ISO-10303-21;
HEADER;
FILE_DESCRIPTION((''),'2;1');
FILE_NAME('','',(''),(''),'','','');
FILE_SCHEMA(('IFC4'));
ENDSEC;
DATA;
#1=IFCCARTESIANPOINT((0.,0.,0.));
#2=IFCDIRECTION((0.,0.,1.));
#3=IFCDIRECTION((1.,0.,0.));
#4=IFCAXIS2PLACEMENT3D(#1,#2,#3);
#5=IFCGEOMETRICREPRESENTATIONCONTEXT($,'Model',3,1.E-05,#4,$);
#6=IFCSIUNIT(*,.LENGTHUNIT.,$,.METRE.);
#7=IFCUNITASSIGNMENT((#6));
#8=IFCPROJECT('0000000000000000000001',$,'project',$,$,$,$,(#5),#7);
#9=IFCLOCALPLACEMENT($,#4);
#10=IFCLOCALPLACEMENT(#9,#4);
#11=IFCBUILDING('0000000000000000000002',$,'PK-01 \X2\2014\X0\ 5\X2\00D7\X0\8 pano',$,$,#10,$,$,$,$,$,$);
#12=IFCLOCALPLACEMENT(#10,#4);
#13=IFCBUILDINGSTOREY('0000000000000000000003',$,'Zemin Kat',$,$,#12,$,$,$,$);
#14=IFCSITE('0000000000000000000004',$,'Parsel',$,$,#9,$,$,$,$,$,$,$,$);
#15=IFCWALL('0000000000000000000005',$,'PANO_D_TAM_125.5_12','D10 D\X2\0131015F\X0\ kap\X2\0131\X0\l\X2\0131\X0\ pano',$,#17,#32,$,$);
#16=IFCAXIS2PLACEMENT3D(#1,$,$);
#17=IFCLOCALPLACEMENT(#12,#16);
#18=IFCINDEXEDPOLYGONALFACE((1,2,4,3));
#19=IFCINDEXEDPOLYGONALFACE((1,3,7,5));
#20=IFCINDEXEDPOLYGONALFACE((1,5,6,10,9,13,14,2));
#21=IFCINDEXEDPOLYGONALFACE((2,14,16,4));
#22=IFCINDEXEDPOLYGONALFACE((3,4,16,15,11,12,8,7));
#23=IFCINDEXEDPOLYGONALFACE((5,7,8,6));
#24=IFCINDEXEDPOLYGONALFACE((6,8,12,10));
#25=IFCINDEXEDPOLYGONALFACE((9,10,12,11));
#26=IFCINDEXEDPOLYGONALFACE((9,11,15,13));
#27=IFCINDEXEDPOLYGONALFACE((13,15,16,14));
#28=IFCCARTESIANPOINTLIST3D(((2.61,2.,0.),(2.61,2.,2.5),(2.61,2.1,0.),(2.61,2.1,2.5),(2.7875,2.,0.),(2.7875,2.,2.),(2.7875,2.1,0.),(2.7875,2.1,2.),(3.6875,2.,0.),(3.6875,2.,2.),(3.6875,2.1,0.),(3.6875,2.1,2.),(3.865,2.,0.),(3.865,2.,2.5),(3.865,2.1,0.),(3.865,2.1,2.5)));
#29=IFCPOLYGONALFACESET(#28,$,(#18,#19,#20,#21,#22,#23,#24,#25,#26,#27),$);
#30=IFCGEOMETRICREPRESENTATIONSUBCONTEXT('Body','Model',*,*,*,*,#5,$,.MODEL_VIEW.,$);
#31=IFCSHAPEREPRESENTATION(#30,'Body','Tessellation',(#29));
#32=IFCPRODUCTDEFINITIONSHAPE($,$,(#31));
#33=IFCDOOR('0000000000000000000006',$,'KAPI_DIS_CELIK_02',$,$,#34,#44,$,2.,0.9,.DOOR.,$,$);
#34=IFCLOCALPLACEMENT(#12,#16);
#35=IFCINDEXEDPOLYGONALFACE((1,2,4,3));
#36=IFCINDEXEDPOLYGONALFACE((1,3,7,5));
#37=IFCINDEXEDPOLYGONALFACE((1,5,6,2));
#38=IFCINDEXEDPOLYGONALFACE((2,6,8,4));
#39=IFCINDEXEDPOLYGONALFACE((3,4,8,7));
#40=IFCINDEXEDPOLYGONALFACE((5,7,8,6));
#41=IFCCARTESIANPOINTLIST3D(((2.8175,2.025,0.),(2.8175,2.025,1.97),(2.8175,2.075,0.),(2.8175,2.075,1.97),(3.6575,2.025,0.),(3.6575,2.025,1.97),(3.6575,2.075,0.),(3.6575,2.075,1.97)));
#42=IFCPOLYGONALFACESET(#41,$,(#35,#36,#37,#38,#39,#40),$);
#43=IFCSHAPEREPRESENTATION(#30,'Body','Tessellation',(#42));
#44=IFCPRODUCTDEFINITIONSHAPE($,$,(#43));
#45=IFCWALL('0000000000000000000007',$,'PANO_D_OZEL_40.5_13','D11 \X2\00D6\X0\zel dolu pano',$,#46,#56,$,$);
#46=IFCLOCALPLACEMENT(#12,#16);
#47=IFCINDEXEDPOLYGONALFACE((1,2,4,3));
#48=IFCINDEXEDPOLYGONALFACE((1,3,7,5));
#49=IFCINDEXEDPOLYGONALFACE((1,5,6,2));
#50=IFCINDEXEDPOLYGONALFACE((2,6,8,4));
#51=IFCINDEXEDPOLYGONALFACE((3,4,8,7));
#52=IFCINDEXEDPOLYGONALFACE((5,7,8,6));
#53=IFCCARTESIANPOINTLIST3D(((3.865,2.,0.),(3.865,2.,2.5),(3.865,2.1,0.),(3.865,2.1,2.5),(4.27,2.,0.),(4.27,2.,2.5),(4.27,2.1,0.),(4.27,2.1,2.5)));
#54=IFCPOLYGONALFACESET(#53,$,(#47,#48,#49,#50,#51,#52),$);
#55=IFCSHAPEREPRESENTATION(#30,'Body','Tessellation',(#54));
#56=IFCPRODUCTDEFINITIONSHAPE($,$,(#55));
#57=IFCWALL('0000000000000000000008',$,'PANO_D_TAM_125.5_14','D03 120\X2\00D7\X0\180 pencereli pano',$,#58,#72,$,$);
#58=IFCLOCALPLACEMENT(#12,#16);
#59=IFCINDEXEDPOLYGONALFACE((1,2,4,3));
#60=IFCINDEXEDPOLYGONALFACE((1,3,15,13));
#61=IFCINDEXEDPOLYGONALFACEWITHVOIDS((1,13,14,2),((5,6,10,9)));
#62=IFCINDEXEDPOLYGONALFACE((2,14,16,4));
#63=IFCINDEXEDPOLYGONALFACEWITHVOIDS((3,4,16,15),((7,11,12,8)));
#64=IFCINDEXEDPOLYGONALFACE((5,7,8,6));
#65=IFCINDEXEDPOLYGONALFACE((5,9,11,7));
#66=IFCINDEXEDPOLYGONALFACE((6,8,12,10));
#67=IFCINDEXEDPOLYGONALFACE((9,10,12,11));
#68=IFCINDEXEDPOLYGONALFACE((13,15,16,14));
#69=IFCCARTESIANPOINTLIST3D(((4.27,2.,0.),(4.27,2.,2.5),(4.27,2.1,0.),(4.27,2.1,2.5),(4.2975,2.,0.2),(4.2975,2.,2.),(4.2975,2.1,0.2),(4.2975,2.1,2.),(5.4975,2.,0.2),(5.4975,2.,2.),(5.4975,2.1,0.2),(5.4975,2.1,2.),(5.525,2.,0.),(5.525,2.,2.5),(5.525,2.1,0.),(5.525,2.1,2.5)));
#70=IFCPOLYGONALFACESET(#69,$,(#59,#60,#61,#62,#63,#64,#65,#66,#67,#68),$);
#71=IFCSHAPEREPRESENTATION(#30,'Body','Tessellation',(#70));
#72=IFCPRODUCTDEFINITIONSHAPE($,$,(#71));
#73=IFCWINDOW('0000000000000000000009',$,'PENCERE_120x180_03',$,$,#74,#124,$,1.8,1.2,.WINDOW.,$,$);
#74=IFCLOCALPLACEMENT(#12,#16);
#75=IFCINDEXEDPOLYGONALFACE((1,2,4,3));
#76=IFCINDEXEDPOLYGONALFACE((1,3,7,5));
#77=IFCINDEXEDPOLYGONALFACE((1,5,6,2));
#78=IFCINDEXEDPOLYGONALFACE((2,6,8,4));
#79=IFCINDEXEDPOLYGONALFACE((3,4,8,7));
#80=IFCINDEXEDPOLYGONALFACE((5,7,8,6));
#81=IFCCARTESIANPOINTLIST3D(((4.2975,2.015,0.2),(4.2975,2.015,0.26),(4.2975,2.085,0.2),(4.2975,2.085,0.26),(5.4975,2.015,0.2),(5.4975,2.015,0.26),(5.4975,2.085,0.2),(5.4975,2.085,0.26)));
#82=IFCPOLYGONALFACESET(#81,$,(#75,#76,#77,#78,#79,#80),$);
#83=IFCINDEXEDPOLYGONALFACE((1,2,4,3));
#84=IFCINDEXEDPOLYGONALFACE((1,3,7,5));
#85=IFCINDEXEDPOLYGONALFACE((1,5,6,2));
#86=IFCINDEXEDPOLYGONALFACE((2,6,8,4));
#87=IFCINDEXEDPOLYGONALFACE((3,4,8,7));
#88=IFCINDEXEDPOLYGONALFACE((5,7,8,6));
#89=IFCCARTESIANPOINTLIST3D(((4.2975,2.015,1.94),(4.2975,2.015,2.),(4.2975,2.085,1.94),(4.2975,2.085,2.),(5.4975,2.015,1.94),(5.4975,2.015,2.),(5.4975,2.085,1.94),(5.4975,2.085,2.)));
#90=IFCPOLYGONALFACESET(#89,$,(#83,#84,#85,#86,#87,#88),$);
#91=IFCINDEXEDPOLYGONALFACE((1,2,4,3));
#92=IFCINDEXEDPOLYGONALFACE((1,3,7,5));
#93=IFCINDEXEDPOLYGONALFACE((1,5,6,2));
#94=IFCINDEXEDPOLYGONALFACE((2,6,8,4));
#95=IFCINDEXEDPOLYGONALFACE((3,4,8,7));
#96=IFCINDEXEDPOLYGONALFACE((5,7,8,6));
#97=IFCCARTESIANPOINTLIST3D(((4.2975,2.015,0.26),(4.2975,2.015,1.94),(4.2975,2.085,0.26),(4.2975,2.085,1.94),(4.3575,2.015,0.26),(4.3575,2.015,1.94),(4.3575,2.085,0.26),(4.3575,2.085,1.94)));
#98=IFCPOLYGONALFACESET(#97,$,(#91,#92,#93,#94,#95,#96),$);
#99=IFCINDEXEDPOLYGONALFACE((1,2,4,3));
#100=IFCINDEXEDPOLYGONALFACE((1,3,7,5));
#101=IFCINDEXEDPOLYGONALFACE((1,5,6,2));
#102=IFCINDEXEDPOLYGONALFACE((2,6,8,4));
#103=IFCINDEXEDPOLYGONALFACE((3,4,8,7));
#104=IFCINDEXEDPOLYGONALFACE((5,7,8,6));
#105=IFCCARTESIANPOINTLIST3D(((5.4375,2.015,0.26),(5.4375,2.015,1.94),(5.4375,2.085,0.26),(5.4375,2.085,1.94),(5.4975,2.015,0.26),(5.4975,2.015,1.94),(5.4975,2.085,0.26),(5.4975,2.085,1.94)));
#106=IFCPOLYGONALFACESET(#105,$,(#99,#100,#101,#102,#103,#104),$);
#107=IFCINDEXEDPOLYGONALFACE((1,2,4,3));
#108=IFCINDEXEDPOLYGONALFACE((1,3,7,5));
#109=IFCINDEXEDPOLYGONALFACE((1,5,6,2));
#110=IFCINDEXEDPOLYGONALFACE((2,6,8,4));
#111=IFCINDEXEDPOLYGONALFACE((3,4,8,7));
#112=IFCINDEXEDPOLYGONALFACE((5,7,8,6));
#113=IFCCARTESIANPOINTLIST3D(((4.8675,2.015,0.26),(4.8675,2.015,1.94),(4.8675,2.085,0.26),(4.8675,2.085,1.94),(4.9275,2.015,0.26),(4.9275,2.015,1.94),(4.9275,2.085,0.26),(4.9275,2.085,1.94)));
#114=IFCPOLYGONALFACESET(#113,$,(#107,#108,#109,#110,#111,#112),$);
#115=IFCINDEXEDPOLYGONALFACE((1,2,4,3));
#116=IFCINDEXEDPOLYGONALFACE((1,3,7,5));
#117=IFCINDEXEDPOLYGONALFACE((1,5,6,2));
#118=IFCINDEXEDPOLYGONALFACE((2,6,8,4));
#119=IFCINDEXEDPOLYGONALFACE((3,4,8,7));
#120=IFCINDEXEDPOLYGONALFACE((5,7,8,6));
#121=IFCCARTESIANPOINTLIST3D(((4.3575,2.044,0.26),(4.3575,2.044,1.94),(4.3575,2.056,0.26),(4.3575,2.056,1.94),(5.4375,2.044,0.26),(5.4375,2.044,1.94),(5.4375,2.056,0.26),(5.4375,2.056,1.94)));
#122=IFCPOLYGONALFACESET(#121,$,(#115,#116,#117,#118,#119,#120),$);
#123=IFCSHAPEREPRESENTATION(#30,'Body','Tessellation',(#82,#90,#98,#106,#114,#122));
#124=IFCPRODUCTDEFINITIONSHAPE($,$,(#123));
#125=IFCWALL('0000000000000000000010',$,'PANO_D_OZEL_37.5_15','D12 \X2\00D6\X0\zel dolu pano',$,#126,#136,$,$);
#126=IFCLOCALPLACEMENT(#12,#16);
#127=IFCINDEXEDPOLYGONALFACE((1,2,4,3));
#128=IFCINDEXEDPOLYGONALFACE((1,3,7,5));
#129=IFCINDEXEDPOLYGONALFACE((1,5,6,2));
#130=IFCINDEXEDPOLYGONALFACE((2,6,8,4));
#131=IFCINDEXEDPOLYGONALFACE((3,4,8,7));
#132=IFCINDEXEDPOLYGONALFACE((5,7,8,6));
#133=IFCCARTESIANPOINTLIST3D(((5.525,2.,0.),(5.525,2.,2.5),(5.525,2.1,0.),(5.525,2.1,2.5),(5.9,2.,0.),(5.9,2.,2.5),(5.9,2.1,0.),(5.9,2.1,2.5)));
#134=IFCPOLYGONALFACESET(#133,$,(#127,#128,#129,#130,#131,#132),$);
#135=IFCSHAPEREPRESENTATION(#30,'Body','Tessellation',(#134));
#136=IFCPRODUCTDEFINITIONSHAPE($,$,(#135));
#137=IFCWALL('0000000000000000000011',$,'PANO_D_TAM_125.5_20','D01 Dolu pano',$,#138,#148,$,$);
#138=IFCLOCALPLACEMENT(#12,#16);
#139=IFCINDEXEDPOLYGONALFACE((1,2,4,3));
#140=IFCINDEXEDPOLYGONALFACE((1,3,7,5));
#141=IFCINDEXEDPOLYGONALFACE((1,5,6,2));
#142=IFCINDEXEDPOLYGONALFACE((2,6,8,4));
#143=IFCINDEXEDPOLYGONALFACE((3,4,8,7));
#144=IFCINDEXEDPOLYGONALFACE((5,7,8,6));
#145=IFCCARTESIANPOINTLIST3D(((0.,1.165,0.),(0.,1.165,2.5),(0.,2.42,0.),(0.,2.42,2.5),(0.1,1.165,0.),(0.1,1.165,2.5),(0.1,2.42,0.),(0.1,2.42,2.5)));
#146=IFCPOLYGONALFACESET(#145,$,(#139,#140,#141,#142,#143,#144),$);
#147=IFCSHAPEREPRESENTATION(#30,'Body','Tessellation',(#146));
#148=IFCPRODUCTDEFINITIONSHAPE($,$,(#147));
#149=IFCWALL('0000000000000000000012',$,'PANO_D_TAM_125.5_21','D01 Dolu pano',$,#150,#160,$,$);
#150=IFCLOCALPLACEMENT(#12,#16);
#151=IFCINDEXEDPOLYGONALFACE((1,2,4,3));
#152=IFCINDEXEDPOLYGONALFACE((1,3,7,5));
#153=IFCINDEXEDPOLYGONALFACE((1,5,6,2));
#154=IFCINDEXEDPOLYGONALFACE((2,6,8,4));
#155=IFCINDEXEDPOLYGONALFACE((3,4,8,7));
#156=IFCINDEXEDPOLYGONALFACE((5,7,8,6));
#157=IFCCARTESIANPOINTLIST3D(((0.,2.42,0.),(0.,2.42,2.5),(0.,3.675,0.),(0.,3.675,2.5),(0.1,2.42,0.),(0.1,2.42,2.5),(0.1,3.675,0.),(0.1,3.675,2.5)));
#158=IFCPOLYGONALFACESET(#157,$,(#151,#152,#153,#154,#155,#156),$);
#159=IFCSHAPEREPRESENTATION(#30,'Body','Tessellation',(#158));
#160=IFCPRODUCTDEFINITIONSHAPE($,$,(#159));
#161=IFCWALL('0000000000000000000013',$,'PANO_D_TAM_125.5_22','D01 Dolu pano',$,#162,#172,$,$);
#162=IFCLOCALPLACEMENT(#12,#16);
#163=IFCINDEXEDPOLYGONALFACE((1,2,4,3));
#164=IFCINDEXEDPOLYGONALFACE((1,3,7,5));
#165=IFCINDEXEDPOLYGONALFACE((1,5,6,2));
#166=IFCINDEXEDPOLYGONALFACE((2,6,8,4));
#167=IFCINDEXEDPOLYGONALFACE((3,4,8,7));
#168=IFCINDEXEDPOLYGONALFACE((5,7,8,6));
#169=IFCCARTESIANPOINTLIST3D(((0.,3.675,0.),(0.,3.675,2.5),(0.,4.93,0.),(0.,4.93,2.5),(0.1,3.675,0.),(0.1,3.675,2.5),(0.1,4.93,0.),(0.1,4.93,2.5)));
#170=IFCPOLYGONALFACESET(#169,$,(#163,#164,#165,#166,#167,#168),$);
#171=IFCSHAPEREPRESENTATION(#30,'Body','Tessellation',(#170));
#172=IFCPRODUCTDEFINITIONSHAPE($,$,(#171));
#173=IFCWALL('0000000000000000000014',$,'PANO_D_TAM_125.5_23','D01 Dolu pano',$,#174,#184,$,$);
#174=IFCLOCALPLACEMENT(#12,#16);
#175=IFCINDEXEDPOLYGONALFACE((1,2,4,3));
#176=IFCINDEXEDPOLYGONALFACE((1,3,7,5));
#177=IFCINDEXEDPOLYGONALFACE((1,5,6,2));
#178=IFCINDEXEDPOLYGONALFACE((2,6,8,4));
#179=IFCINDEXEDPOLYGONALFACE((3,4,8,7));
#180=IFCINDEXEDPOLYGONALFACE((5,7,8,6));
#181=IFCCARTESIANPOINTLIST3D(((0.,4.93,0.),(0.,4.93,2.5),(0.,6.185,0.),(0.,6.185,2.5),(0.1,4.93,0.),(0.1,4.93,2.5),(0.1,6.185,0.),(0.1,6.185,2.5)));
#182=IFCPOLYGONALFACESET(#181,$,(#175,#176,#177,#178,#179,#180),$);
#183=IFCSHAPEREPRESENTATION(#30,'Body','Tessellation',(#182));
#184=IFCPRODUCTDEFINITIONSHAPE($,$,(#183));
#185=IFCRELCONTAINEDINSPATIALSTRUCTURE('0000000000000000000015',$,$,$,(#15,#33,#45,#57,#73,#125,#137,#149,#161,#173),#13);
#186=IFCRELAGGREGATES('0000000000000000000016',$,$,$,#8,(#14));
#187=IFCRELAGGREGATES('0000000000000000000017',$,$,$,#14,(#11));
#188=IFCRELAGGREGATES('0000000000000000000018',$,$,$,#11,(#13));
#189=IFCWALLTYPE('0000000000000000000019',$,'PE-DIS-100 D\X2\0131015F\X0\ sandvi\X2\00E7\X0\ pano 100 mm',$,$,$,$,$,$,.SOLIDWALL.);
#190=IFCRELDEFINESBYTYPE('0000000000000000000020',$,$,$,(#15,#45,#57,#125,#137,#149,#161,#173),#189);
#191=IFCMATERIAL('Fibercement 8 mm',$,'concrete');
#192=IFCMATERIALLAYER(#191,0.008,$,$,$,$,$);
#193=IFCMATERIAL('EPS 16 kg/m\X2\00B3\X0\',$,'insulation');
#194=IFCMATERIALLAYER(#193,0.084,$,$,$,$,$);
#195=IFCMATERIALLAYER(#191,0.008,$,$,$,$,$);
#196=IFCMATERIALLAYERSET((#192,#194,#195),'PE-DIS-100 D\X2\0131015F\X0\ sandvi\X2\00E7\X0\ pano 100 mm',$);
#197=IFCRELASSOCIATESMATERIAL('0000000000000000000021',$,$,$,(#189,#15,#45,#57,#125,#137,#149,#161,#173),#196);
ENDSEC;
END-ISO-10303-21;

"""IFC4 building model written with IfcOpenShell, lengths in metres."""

from ifc_helpers import new_model, si_unit, frame, origin_with_axes, place, context, subcontext, project, spatial, line, indexed_curve, outline, extrude, material, layer, layer_set, layer_usage, type_object, element, fill, save


model = new_model("IFC4")

# Units and contexts
model_context = context("Model", 3, precision=1e-05, world=origin_with_axes())
body_context = subcontext(model_context, "Body", "Model", "MODEL_VIEW")
ifc_project = project(units=[si_unit("LENGTHUNIT", "METRE")], contexts=[model_context])

# Site, building, storey
site_placement = place(None, origin_with_axes())
site = spatial("IfcSite", under=ifc_project, at=site_placement, Name="Parsel")
building_placement = place(site_placement, origin_with_axes())
building = spatial("IfcBuilding", under=site, at=building_placement, Name="PK-01 — 5×8 pano")
storey_placement = place(building_placement, origin_with_axes())
storey = spatial("IfcBuildingStorey", under=building, at=storey_placement, Name="Zemin Kat")

# Wall, opening, door
ifc_material_1 = material(Name="Fibercement 8 mm", Category="concrete")
ifc_layer_1 = layer(ifc_material_1, 0.008)
ifc_material_2 = material(Name="EPS 16 kg/m³", Category="insulation")
ifc_layer_2 = layer(ifc_material_2, 0.084)
ifc_layer_3 = layer(ifc_material_1, 0.008)
ifc_layer_set_1 = layer_set([ifc_layer_1, ifc_layer_2, ifc_layer_3], Name="PE-DIS-100 Dış sandviç pano 100 mm")
ifc_layer_usage_1 = layer_usage(ifc_layer_set_1, "AXIS2", "POSITIVE", 0.0)
wall_type_1 = type_object("IfcWallType", Name="PE-DIS-100 Dış sandviç pano 100 mm", PredefinedType="SOLIDWALL", material=ifc_layer_set_1)
wall_1_placement = place(storey_placement, frame((2.61, 2.0, 0.0), z_axis=(0.0, 0.0, 1.0), x_axis=(1.0, 0.0, 0.0)))
wall_1 = element("IfcWall", 1, at=wall_1_placement, inside=storey, type_object=wall_type_1, material=ifc_layer_usage_1, Name="PANO_D_TAM_125.5_12", Description="D10 Dış kapılı pano", context=body_context, shape_type="SweptSolid", body=[
    extrude(outline(indexed_curve([(0.0, 0.0), (1.255, 0.0), (1.255, 0.1), (0.0, 0.1)], segments=[line(1, 2, 3, 4, 1)])), origin_with_axes(), (0.0, 0.0, 1.0), 2.5),
])
opening_1_placement = place(wall_1_placement, origin_with_axes())
opening_1 = element("IfcOpeningElement", 2, at=opening_1_placement, cuts=wall_1, PredefinedType="OPENING", context=body_context, shape_type="SweptSolid", body=[
    extrude(outline(indexed_curve([(0.0, 0.0), (0.9, 0.0), (0.9, 0.14), (0.0, 0.14)], segments=[line(1, 2, 3, 4, 1)])), frame((0.1775, -0.02, 0.0), z_axis=(0.0, 0.0, 1.0), x_axis=(1.0, 0.0, 0.0)), (0.0, 0.0, 1.0), 2.0),
])
door_1_placement = place(storey_placement, frame((2.61, 2.0, 0.0), z_axis=(0.0, 0.0, 1.0), x_axis=(1.0, 0.0, 0.0)))
door_1 = element("IfcDoor", 3, at=door_1_placement, inside=storey, Name="KAPI_DIS_CELIK_02", OverallHeight=2.0, OverallWidth=0.9, PredefinedType="DOOR", context=body_context, shape_type="SweptSolid", body=[
    extrude(outline(indexed_curve([(0.0, 0.0), (0.84, 0.0), (0.84, 0.05), (0.0, 0.05)], segments=[line(1, 2, 3, 4, 1)])), frame((0.2075, 0.025, 0.0), z_axis=(0.0, 0.0, 1.0), x_axis=(1.0, 0.0, 0.0)), (0.0, 0.0, 1.0), 1.97),
])
fill(opening_1, door_1)

# Wall
ifc_layer_usage_2 = layer_usage(ifc_layer_set_1, "AXIS2", "POSITIVE", 0.0)
wall_2_placement = place(storey_placement, frame((3.865, 2.0, 0.0), z_axis=(0.0, 0.0, 1.0), x_axis=(1.0, 0.0, 0.0)))
element("IfcWall", 4, at=wall_2_placement, inside=storey, type_object=wall_type_1, material=ifc_layer_usage_2, Name="PANO_D_OZEL_40.5_13", Description="D11 Özel dolu pano", context=body_context, shape_type="SweptSolid", body=[
    extrude(outline(indexed_curve([(0.0, 0.0), (0.405, 0.0), (0.405, 0.1), (0.0, 0.1)], segments=[line(1, 2, 3, 4, 1)])), origin_with_axes(), (0.0, 0.0, 1.0), 2.5),
])

# Wall, opening, window
ifc_layer_usage_3 = layer_usage(ifc_layer_set_1, "AXIS2", "POSITIVE", 0.0)
wall_3_placement = place(storey_placement, frame((4.27, 2.0, 0.0), z_axis=(0.0, 0.0, 1.0), x_axis=(1.0, 0.0, 0.0)))
wall_3 = element("IfcWall", 5, at=wall_3_placement, inside=storey, type_object=wall_type_1, material=ifc_layer_usage_3, Name="PANO_D_TAM_125.5_14", Description="D03 120×180 pencereli pano", context=body_context, shape_type="SweptSolid", body=[
    extrude(outline(indexed_curve([(0.0, 0.0), (1.255, 0.0), (1.255, 0.1), (0.0, 0.1)], segments=[line(1, 2, 3, 4, 1)])), origin_with_axes(), (0.0, 0.0, 1.0), 2.5),
])
opening_2_placement = place(wall_3_placement, origin_with_axes())
opening_2 = element("IfcOpeningElement", 6, at=opening_2_placement, cuts=wall_3, PredefinedType="OPENING", context=body_context, shape_type="SweptSolid", body=[
    extrude(outline(indexed_curve([(0.0, 0.0), (1.2, 0.0), (1.2, 0.14), (0.0, 0.14)], segments=[line(1, 2, 3, 4, 1)])), frame((0.0275, -0.02, 0.2), z_axis=(0.0, 0.0, 1.0), x_axis=(1.0, 0.0, 0.0)), (0.0, 0.0, 1.0), 1.8),
])
window_1_placement = place(storey_placement, frame((4.27, 2.0, 0.0), z_axis=(0.0, 0.0, 1.0), x_axis=(1.0, 0.0, 0.0)))
window_1 = element("IfcWindow", 7, at=window_1_placement, inside=storey, Name="PENCERE_120x180_03", OverallHeight=1.8, OverallWidth=1.2, PredefinedType="WINDOW", context=body_context, shape_type="SweptSolid", body=[
    extrude(outline(indexed_curve([(0.0, 0.0), (1.2, 0.0), (1.2, 0.07), (0.0, 0.07)], segments=[line(1, 2, 3, 4, 1)])), frame((0.0275, 0.015, 0.2), z_axis=(0.0, 0.0, 1.0), x_axis=(1.0, 0.0, 0.0)), (0.0, 0.0, 1.0), 0.06),
    extrude(outline(indexed_curve([(0.0, 0.0), (1.2, 0.0), (1.2, 0.07), (0.0, 0.07)], segments=[line(1, 2, 3, 4, 1)])), frame((0.0275, 0.015, 1.94), z_axis=(0.0, 0.0, 1.0), x_axis=(1.0, 0.0, 0.0)), (0.0, 0.0, 1.0), 0.06),
    extrude(outline(indexed_curve([(0.0, 0.0), (0.06, 0.0), (0.06, 0.07), (0.0, 0.07)], segments=[line(1, 2, 3, 4, 1)])), frame((0.0275, 0.015, 0.26), z_axis=(0.0, 0.0, 1.0), x_axis=(1.0, 0.0, 0.0)), (0.0, 0.0, 1.0), 1.68),
    extrude(outline(indexed_curve([(0.0, 0.0), (0.06, 0.0), (0.06, 0.07), (0.0, 0.07)], segments=[line(1, 2, 3, 4, 1)])), frame((1.1675, 0.015, 0.26), z_axis=(0.0, 0.0, 1.0), x_axis=(1.0, 0.0, 0.0)), (0.0, 0.0, 1.0), 1.68),
    extrude(outline(indexed_curve([(0.0, 0.0), (0.06, 0.0), (0.06, 0.07), (0.0, 0.07)], segments=[line(1, 2, 3, 4, 1)])), frame((0.5975, 0.015, 0.26), z_axis=(0.0, 0.0, 1.0), x_axis=(1.0, 0.0, 0.0)), (0.0, 0.0, 1.0), 1.68),
    extrude(outline(indexed_curve([(0.0, 0.0), (1.08, 0.0), (1.08, 0.012), (0.0, 0.012)], segments=[line(1, 2, 3, 4, 1)])), frame((0.0875, 0.044, 0.26), z_axis=(0.0, 0.0, 1.0), x_axis=(1.0, 0.0, 0.0)), (0.0, 0.0, 1.0), 1.68),
])
fill(opening_2, window_1)

# Walls
ifc_layer_usage_4 = layer_usage(ifc_layer_set_1, "AXIS2", "POSITIVE", 0.0)
wall_4_placement = place(storey_placement, frame((5.525, 2.0, 0.0), z_axis=(0.0, 0.0, 1.0), x_axis=(1.0, 0.0, 0.0)))
element("IfcWall", 8, at=wall_4_placement, inside=storey, type_object=wall_type_1, material=ifc_layer_usage_4, Name="PANO_D_OZEL_37.5_15", Description="D12 Özel dolu pano", context=body_context, shape_type="SweptSolid", body=[
    extrude(outline(indexed_curve([(0.0, 0.0), (0.375, 0.0), (0.375, 0.1), (0.0, 0.1)], segments=[line(1, 2, 3, 4, 1)])), origin_with_axes(), (0.0, 0.0, 1.0), 2.5),
])
ifc_layer_usage_5 = layer_usage(ifc_layer_set_1, "AXIS2", "POSITIVE", 0.0)
wall_5_placement = place(storey_placement, frame((0.1, 1.165, 0.0), z_axis=(0.0, 0.0, 1.0), x_axis=(0.0, 1.0, 0.0)))
element("IfcWall", 9, at=wall_5_placement, inside=storey, type_object=wall_type_1, material=ifc_layer_usage_5, Name="PANO_D_TAM_125.5_20", Description="D01 Dolu pano", context=body_context, shape_type="SweptSolid", body=[
    extrude(outline(indexed_curve([(0.0, 0.0), (1.255, 0.0), (1.255, 0.1), (0.0, 0.1)], segments=[line(1, 2, 3, 4, 1)])), origin_with_axes(), (0.0, 0.0, 1.0), 2.5),
])
ifc_layer_usage_6 = layer_usage(ifc_layer_set_1, "AXIS2", "POSITIVE", 0.0)
wall_6_placement = place(storey_placement, frame((0.1, 2.42, 0.0), z_axis=(0.0, 0.0, 1.0), x_axis=(0.0, 1.0, 0.0)))
element("IfcWall", 10, at=wall_6_placement, inside=storey, type_object=wall_type_1, material=ifc_layer_usage_6, Name="PANO_D_TAM_125.5_21", Description="D01 Dolu pano", context=body_context, shape_type="SweptSolid", body=[
    extrude(outline(indexed_curve([(0.0, 0.0), (1.255, 0.0), (1.255, 0.1), (0.0, 0.1)], segments=[line(1, 2, 3, 4, 1)])), origin_with_axes(), (0.0, 0.0, 1.0), 2.5),
])
ifc_layer_usage_7 = layer_usage(ifc_layer_set_1, "AXIS2", "POSITIVE", 0.0)
wall_7_placement = place(storey_placement, frame((0.1, 3.675, 0.0), z_axis=(0.0, 0.0, 1.0), x_axis=(0.0, 1.0, 0.0)))
element("IfcWall", 11, at=wall_7_placement, inside=storey, type_object=wall_type_1, material=ifc_layer_usage_7, Name="PANO_D_TAM_125.5_22", Description="D01 Dolu pano", context=body_context, shape_type="SweptSolid", body=[
    extrude(outline(indexed_curve([(0.0, 0.0), (1.255, 0.0), (1.255, 0.1), (0.0, 0.1)], segments=[line(1, 2, 3, 4, 1)])), origin_with_axes(), (0.0, 0.0, 1.0), 2.5),
])
ifc_layer_usage_8 = layer_usage(ifc_layer_set_1, "AXIS2", "POSITIVE", 0.0)
wall_8_placement = place(storey_placement, frame((0.1, 4.93, 0.0), z_axis=(0.0, 0.0, 1.0), x_axis=(0.0, 1.0, 0.0)))
element("IfcWall", 12, at=wall_8_placement, inside=storey, type_object=wall_type_1, material=ifc_layer_usage_8, Name="PANO_D_TAM_125.5_23", Description="D01 Dolu pano", context=body_context, shape_type="SweptSolid", body=[
    extrude(outline(indexed_curve([(0.0, 0.0), (1.255, 0.0), (1.255, 0.1), (0.0, 0.1)], segments=[line(1, 2, 3, 4, 1)])), origin_with_axes(), (0.0, 0.0, 1.0), 2.5),
])

save(model, "model.ifc")
